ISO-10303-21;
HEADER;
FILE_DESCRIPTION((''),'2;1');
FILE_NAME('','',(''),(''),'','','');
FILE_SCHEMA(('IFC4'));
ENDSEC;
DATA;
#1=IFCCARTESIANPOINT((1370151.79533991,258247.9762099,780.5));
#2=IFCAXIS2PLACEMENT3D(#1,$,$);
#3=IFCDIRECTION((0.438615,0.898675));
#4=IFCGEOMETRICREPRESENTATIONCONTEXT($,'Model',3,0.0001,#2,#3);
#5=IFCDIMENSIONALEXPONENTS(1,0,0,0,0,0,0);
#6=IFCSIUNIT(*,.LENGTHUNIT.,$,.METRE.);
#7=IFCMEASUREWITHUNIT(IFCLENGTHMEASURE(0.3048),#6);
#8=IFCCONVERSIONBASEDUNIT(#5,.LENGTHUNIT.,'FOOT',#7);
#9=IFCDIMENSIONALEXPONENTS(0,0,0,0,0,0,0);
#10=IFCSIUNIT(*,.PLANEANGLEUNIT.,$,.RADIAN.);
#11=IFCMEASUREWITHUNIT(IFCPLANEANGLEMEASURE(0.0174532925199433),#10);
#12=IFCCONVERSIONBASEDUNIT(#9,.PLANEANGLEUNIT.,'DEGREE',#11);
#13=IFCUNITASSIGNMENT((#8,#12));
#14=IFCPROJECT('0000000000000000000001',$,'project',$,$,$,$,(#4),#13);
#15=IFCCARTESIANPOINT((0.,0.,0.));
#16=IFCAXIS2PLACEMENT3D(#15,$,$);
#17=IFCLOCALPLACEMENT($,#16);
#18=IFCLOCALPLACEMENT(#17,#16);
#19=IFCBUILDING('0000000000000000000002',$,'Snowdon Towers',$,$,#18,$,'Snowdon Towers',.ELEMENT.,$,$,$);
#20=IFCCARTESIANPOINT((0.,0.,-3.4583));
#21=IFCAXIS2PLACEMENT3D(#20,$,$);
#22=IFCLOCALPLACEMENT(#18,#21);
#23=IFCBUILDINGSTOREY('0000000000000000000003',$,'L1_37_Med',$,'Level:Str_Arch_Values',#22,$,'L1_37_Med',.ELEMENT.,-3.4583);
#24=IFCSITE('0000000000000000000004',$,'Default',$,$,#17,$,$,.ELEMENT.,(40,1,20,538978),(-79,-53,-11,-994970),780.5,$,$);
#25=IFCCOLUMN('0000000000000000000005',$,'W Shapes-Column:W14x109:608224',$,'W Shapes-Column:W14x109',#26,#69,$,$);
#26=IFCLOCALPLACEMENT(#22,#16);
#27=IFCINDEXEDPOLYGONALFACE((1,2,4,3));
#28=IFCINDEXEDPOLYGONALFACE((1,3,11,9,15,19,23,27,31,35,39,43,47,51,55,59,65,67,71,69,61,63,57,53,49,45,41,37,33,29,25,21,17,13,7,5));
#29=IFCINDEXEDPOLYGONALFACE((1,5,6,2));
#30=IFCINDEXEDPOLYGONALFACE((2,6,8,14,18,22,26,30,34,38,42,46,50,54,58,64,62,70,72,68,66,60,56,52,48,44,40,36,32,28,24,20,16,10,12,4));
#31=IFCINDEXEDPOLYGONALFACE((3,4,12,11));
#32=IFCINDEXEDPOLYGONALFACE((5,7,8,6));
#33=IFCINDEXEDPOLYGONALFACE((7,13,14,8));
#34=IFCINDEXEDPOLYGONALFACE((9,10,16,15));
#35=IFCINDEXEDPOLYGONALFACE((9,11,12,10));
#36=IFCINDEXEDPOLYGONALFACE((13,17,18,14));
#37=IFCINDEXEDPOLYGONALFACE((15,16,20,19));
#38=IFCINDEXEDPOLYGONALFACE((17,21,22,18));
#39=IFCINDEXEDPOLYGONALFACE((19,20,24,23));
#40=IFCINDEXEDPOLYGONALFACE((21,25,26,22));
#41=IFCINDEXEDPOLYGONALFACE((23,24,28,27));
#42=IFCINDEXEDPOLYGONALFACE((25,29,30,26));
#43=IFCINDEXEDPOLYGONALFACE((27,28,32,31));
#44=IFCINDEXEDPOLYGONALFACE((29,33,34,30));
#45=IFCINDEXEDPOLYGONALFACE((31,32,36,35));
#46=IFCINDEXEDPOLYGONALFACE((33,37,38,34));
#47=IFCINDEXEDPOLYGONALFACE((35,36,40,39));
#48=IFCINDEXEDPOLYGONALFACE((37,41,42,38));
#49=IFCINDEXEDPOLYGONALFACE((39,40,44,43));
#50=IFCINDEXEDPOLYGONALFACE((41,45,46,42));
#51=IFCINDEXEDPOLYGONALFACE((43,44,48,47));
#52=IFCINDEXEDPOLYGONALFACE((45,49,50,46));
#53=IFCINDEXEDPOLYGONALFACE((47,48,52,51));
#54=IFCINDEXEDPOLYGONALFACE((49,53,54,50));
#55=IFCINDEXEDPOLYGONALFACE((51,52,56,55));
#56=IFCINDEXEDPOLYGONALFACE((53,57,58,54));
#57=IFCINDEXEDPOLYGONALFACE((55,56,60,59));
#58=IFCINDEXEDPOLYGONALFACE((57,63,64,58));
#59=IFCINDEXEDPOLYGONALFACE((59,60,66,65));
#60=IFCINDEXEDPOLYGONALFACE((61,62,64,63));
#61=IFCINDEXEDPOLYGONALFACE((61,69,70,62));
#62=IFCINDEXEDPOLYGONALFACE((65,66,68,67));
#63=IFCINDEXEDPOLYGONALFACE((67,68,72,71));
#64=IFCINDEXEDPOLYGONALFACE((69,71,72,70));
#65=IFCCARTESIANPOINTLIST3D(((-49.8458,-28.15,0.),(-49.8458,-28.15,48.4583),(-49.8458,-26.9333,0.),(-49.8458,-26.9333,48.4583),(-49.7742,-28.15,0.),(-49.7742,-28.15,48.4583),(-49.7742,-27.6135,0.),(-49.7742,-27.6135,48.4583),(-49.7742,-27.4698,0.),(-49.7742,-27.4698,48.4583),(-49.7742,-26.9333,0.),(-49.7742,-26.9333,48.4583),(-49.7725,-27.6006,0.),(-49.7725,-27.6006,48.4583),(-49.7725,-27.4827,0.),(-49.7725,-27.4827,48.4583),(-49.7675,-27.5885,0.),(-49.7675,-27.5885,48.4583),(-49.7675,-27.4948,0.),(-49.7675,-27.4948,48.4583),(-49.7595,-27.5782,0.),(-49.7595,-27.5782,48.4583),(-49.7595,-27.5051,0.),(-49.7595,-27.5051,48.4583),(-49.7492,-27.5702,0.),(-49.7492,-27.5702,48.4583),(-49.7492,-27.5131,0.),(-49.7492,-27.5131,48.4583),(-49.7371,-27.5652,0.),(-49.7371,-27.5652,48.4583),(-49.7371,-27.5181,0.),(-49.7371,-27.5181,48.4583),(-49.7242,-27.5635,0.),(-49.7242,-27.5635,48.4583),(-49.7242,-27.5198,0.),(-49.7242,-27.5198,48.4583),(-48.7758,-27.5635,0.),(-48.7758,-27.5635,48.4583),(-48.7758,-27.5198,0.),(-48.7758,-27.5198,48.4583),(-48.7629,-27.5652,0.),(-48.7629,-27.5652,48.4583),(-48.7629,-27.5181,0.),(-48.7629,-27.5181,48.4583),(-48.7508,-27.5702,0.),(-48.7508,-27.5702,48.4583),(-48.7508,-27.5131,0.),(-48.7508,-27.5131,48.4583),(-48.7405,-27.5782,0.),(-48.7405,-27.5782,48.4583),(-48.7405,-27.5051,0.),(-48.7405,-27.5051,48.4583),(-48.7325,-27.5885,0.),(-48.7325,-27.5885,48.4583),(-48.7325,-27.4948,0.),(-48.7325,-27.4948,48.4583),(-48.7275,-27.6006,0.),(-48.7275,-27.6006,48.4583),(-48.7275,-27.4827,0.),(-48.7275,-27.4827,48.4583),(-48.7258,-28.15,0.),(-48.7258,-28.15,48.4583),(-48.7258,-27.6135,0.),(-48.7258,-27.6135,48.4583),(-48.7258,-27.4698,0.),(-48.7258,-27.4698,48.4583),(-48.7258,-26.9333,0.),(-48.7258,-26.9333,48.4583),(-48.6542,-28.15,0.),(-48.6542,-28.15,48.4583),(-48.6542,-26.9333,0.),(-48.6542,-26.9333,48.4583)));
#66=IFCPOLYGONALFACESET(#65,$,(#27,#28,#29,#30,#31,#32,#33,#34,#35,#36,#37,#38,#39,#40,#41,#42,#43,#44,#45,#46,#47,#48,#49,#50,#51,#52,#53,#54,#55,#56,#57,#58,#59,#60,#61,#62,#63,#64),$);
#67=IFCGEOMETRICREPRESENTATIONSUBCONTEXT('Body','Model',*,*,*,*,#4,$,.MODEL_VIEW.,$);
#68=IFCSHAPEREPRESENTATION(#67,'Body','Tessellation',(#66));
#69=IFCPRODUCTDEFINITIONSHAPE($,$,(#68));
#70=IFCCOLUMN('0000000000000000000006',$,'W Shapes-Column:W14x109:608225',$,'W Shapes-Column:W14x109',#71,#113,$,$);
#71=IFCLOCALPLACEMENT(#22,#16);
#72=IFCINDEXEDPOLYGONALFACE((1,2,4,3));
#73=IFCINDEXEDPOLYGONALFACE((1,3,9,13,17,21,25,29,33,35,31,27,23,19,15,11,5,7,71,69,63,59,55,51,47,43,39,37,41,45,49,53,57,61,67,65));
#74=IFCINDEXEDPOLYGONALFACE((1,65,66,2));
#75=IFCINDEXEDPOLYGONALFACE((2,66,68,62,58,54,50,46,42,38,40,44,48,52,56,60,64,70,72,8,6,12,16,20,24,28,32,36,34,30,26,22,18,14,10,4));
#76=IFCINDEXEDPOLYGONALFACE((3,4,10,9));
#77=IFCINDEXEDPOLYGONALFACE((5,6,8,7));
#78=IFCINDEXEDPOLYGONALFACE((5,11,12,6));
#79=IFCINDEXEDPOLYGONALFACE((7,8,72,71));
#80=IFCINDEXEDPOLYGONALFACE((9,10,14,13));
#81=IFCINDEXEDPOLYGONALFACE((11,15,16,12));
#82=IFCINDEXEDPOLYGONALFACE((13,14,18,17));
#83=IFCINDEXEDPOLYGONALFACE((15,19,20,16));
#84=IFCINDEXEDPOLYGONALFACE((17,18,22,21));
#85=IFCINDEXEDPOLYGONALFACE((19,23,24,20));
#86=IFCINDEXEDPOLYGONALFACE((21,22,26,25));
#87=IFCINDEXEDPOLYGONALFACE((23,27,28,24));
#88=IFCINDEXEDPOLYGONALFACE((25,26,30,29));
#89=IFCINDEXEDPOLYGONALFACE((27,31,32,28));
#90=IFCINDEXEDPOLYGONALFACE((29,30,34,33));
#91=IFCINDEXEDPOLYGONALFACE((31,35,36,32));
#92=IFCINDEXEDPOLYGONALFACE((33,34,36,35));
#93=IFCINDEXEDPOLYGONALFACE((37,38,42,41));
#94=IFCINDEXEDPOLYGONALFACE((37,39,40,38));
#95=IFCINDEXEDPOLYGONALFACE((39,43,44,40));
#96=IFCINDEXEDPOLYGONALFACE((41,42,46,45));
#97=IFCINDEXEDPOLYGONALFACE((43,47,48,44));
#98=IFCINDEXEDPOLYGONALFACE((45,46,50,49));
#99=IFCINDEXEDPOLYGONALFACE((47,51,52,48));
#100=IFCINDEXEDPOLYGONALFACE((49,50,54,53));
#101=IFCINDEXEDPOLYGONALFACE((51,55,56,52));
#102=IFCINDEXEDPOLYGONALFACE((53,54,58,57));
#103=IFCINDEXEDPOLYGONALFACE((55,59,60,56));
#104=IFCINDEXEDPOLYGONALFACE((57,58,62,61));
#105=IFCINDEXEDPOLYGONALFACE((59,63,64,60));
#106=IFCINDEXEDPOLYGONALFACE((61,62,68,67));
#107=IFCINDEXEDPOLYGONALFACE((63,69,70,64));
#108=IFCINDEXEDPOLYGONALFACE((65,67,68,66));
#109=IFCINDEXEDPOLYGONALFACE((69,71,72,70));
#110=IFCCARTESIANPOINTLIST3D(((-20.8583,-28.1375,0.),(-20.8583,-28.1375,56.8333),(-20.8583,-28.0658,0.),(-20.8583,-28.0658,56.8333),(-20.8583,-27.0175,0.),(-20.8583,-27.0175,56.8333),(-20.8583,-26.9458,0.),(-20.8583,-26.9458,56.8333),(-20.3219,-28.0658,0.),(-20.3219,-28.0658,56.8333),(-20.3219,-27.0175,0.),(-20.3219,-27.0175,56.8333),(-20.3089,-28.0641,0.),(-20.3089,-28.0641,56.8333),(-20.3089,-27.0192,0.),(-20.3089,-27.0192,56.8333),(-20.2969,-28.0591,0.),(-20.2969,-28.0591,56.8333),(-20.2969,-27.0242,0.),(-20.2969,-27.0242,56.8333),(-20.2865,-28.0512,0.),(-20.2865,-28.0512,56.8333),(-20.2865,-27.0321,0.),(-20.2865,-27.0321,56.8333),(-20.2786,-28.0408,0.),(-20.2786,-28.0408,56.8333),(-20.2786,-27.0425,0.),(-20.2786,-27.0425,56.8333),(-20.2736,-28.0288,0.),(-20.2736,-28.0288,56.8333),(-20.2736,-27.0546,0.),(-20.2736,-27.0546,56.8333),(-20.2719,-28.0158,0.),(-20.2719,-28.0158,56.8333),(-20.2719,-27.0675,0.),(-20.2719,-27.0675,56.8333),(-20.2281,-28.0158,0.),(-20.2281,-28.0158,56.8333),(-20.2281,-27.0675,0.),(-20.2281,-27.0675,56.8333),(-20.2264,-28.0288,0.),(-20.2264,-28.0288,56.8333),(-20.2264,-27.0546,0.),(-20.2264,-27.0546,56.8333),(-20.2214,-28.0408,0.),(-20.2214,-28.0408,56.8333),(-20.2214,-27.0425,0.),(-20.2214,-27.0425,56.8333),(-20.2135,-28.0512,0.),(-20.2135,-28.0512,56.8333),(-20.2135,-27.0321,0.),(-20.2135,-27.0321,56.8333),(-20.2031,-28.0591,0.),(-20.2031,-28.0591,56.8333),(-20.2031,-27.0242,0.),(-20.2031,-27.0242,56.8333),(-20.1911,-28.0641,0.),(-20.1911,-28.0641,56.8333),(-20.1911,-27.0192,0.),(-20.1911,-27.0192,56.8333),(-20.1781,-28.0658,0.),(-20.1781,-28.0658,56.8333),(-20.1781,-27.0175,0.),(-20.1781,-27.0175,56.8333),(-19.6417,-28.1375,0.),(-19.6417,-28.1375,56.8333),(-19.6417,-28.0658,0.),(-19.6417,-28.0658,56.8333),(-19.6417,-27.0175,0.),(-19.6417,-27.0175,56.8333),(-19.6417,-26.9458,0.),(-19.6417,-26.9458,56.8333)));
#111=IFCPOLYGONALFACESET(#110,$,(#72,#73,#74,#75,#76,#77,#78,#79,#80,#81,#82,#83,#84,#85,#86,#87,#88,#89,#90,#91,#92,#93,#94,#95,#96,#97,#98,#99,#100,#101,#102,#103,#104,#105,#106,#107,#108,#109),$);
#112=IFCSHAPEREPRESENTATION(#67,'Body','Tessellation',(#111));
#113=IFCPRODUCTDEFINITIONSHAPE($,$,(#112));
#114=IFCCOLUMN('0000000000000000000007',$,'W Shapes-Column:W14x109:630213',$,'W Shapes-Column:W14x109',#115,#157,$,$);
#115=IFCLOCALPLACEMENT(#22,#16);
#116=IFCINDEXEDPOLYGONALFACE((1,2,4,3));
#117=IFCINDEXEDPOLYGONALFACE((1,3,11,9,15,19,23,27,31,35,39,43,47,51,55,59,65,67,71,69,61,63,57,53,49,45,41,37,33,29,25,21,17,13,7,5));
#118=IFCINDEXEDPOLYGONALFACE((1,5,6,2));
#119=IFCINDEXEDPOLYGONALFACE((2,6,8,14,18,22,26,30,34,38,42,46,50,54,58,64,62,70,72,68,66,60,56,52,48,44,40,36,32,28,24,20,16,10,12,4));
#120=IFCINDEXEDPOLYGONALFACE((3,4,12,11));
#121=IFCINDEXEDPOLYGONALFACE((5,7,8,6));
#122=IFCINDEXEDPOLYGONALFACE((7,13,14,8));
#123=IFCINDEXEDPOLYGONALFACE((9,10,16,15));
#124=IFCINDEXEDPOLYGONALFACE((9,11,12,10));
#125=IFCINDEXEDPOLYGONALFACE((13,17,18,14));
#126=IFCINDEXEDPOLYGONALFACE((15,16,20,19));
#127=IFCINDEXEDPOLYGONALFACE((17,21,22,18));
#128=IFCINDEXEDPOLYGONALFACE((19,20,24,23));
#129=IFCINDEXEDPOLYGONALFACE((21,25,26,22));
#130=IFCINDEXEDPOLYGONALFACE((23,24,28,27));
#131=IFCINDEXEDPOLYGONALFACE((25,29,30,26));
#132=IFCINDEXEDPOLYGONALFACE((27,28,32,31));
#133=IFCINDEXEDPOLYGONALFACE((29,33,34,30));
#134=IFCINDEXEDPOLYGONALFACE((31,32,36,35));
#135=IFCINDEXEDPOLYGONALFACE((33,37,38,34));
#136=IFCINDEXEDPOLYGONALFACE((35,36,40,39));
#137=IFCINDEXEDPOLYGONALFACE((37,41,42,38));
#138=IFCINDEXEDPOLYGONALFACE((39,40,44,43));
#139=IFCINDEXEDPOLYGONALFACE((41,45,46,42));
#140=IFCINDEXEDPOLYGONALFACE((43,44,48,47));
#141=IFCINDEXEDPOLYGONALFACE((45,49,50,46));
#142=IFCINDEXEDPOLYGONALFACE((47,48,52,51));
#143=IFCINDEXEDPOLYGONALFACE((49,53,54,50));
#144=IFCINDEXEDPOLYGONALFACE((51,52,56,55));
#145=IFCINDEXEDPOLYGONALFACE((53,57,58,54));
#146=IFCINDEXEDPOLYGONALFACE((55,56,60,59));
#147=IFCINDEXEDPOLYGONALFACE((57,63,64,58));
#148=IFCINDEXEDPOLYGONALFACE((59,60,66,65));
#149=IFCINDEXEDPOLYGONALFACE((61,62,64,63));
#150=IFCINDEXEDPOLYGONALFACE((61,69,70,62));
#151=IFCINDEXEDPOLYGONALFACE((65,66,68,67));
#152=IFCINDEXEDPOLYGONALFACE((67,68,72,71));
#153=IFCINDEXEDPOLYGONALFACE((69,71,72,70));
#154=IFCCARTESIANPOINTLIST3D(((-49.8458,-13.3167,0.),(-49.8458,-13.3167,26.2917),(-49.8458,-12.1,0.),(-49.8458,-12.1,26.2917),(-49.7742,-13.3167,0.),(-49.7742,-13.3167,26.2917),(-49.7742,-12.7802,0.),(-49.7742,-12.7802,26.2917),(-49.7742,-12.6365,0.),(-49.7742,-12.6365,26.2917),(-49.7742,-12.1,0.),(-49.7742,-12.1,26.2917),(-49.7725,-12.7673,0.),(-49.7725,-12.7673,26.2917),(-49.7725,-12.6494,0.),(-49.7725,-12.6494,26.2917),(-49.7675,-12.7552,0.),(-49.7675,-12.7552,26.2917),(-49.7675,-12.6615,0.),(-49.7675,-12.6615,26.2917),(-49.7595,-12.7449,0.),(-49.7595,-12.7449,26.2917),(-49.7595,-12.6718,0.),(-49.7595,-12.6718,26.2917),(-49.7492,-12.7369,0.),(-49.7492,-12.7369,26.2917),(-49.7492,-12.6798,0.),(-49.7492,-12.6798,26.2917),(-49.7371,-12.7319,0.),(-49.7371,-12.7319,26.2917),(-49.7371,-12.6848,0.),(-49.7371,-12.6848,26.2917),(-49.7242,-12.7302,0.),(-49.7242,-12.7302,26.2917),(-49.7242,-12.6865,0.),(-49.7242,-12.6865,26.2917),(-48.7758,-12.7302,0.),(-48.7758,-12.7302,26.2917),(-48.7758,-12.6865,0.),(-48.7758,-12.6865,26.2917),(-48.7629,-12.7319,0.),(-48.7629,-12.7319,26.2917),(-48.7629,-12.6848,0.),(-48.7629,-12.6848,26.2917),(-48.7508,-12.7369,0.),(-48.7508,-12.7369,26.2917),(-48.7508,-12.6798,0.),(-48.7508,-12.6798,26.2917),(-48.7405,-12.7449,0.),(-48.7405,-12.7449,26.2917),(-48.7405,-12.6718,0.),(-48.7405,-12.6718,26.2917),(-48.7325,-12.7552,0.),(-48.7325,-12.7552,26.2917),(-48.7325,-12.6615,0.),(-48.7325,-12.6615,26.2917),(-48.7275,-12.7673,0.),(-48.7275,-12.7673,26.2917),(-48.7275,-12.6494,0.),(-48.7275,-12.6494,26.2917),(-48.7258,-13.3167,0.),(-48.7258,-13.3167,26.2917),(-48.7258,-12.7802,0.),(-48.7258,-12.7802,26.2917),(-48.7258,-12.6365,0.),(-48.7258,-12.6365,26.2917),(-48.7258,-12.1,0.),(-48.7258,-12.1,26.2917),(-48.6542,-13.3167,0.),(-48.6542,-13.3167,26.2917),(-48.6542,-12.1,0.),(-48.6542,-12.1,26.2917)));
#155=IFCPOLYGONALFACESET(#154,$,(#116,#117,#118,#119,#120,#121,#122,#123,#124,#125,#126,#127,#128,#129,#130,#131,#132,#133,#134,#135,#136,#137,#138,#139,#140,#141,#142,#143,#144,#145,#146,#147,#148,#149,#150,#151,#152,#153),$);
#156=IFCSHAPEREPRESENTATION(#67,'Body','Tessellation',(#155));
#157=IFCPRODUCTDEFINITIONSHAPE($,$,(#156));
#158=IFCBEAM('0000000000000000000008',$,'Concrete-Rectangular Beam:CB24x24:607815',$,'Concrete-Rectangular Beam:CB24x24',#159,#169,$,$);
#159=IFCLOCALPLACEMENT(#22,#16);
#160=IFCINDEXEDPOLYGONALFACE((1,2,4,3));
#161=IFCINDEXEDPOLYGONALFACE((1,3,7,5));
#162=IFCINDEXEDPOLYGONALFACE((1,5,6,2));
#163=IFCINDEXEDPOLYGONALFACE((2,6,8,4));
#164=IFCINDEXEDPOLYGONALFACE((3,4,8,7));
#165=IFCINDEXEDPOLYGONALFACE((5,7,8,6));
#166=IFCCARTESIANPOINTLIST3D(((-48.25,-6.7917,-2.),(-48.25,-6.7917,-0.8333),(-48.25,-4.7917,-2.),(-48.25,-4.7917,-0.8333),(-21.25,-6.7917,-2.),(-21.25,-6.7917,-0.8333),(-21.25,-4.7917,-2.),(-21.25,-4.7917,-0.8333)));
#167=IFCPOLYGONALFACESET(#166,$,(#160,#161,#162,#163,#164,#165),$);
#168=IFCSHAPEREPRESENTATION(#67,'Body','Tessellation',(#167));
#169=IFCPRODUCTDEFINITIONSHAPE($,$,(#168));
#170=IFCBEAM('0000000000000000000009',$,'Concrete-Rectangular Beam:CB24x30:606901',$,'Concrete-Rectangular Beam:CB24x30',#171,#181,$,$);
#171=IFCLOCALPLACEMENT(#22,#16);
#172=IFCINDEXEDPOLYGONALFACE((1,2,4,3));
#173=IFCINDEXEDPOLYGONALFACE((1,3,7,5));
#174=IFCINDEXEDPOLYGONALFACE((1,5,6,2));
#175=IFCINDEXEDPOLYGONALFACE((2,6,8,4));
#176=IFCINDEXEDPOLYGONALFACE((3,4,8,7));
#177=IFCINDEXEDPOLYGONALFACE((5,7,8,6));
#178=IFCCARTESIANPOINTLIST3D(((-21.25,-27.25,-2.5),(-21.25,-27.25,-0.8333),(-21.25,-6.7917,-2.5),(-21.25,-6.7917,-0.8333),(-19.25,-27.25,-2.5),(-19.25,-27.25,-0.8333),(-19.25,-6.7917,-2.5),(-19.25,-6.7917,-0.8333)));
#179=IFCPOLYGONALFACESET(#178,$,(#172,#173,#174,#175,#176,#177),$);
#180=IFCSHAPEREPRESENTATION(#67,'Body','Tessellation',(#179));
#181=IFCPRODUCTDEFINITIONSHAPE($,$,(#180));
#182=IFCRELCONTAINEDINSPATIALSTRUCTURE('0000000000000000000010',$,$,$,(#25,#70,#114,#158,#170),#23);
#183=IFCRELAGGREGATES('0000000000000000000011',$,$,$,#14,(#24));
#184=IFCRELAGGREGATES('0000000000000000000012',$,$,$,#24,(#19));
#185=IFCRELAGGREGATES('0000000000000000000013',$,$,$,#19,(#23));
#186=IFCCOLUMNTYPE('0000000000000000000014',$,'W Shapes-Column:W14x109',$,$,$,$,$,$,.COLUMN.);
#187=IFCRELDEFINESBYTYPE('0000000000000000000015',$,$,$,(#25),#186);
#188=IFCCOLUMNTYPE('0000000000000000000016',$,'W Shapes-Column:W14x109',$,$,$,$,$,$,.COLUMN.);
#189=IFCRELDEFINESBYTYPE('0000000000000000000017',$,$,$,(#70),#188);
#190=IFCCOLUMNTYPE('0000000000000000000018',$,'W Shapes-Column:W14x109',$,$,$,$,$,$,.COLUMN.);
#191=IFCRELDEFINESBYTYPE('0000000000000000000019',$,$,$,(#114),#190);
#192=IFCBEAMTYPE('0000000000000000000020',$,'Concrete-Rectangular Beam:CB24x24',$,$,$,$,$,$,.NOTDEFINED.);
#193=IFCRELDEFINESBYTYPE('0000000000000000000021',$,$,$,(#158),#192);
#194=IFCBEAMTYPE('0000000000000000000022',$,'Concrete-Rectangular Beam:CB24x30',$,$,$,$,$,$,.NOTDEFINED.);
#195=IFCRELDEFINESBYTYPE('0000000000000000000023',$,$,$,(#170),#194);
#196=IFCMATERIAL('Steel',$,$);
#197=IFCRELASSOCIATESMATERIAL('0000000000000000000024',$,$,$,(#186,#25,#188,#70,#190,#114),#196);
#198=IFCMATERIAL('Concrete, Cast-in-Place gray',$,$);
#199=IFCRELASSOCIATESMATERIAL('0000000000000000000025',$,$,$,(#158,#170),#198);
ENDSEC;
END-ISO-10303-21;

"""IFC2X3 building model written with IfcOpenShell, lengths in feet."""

from ifc_helpers import new_model, entity, si_unit, converted_unit, direction, frame, frame_2d, origin, place, context, subcontext, project, spatial, rectangle, i_section, extrude, source, transform, mapped, material, type_object, type_shapes, element, save


model = new_model("IFC2X3")

# Units and contexts
model_context = context("Model", 3, precision=0.0001, world=frame((1370151.79533991, 258247.9762099, 780.5)), true_north=direction((0.438615, 0.898675)))
body_context = subcontext(model_context, "Body", "Model", "MODEL_VIEW")
ifc_project = project(units=[converted_unit("LENGTHUNIT", "FOOT", entity("IfcLengthMeasure", 0.3048), si_unit("LENGTHUNIT", "METRE"), dimensions=[1, 0, 0, 0, 0, 0, 0]), converted_unit("PLANEANGLEUNIT", "DEGREE", entity("IfcPlaneAngleMeasure", 0.0174532925199433), si_unit("PLANEANGLEUNIT", "RADIAN"), dimensions=[0, 0, 0, 0, 0, 0, 0])], contexts=[model_context])

# Site, building, storey
site_placement = place(None, origin())
site = spatial("IfcSite", under=ifc_project, at=site_placement, Name="Default", CompositionType="ELEMENT", RefLatitude=(40, 1, 20, 538978), RefLongitude=(-79, -53, -11, -994970), RefElevation=780.5)
building_placement = place(site_placement, origin())
building = spatial("IfcBuilding", under=site, at=building_placement, Name="Snowdon Towers", LongName="Snowdon Towers", CompositionType="ELEMENT")
storey_placement = place(building_placement, frame((0.0, 0.0, -3.4583)))
storey = spatial("IfcBuildingStorey", under=building, at=storey_placement, Name="L1_37_Med", ObjectType="Level:Str_Arch_Values", LongName="L1_37_Med", CompositionType="ELEMENT", Elevation=-3.4583)

# Columns
ifc_material_1 = material(Name="Steel")
column_type_1 = type_object("IfcColumnType", Name="W Shapes-Column:W14x109", PredefinedType="COLUMN", material=ifc_material_1)
shared_shape_1 = source(origin(), body_context, "Body", "SweptSolid", [
    extrude(i_section(OverallWidth=1.2167, OverallDepth=1.1917, WebThickness=0.0438, FlangeThickness=0.0717, FilletRadius=0.05, at=frame_2d((0.0, 0.0), x_axis=(1.0, 0.0))), frame((0.0, 0.0, -3.4583), z_axis=(0.0, 0.0, 1.0), x_axis=(-1.0, 0.0, 0.0)), (0.0, 0.0, 1.0), 48.4583),
])
type_shapes(column_type_1, [shared_shape_1])
column_1_placement = place(storey_placement, frame((-49.25, -27.5417, 3.4583), z_axis=(0.0, 0.0, 1.0), x_axis=(0.0, 1.0, 0.0)))
element("IfcColumn", 1, at=column_1_placement, inside=storey, type_object=column_type_1, material=ifc_material_1, Name="W Shapes-Column:W14x109:608224", ObjectType="W Shapes-Column:W14x109", context=body_context, shape_type="MappedRepresentation", body=[
    mapped(shared_shape_1, transform((0.0, 0.0, 0.0), scale=1.0)),
])
column_type_2 = type_object("IfcColumnType", Name="W Shapes-Column:W14x109", PredefinedType="COLUMN", material=ifc_material_1)
shared_shape_2 = source(origin(), body_context, "Body", "SweptSolid", [
    extrude(i_section(OverallWidth=1.2167, OverallDepth=1.1917, WebThickness=0.0438, FlangeThickness=0.0717, FilletRadius=0.05, at=frame_2d((0.0, 0.0), x_axis=(1.0, 0.0))), frame((0.0, 0.0, -3.4583), z_axis=(0.0, 0.0, 1.0), x_axis=(-1.0, 0.0, 0.0)), (0.0, 0.0, 1.0), 56.8333),
])
type_shapes(column_type_2, [shared_shape_2])
column_2_placement = place(storey_placement, frame((-20.25, -27.5417, 3.4583), z_axis=(0.0, 0.0, 1.0), x_axis=(-1.0, 0.0, 0.0)))
element("IfcColumn", 2, at=column_2_placement, inside=storey, type_object=column_type_2, material=ifc_material_1, Name="W Shapes-Column:W14x109:608225", ObjectType="W Shapes-Column:W14x109", context=body_context, shape_type="MappedRepresentation", body=[
    mapped(shared_shape_2, transform((0.0, 0.0, 0.0), scale=1.0)),
])
column_type_3 = type_object("IfcColumnType", Name="W Shapes-Column:W14x109", PredefinedType="COLUMN", material=ifc_material_1)
shared_shape_3 = source(origin(), body_context, "Body", "SweptSolid", [
    extrude(i_section(OverallWidth=1.2167, OverallDepth=1.1917, WebThickness=0.0438, FlangeThickness=0.0717, FilletRadius=0.05, at=frame_2d((0.0, 0.0), x_axis=(1.0, 0.0))), frame((0.0, 0.0, -3.4583), z_axis=(0.0, 0.0, 1.0), x_axis=(-1.0, 0.0, 0.0)), (0.0, 0.0, 1.0), 26.2917),
])
type_shapes(column_type_3, [shared_shape_3])
column_3_placement = place(storey_placement, frame((-49.25, -12.7083, 3.4583), z_axis=(0.0, 0.0, 1.0), x_axis=(0.0, 1.0, 0.0)))
element("IfcColumn", 3, at=column_3_placement, inside=storey, type_object=column_type_3, material=ifc_material_1, Name="W Shapes-Column:W14x109:630213", ObjectType="W Shapes-Column:W14x109", context=body_context, shape_type="MappedRepresentation", body=[
    mapped(shared_shape_3, transform((0.0, 0.0, 0.0), scale=1.0)),
])

# Beams
ifc_material_2 = material(Name="Concrete, Cast-in-Place gray")
beam_type_1 = type_object("IfcBeamType", Name="Concrete-Rectangular Beam:CB24x24", PredefinedType="NOTDEFINED")
beam_1_placement = place(storey_placement, frame((-49.25, -5.7917, 0.0)))
element("IfcBeam", 4, at=beam_1_placement, inside=storey, type_object=beam_type_1, material=ifc_material_2, Name="Concrete-Rectangular Beam:CB24x24:607815", ObjectType="Concrete-Rectangular Beam:CB24x24", context=body_context, shape_type="SweptSolid", body=[
    extrude(rectangle(XDim=1.1667, YDim=2.0, at=frame_2d((0.0, 0.0), x_axis=(1.0, 0.0))), frame((1.0, 0.0, -1.4167), z_axis=(1.0, 0.0, 0.0), x_axis=(0.0, 0.0, -1.0)), (0.0, 0.0, 1.0), 27.0),
])
beam_type_2 = type_object("IfcBeamType", Name="Concrete-Rectangular Beam:CB24x30", PredefinedType="NOTDEFINED")
beam_2_placement = place(storey_placement, frame((-20.25, -28.25, 0.0), z_axis=(0.0, 0.0, 1.0), x_axis=(0.0, 1.0, 0.0)))
element("IfcBeam", 5, at=beam_2_placement, inside=storey, type_object=beam_type_2, material=ifc_material_2, Name="Concrete-Rectangular Beam:CB24x30:606901", ObjectType="Concrete-Rectangular Beam:CB24x30", context=body_context, shape_type="SweptSolid", body=[
    extrude(rectangle(XDim=1.6667, YDim=2.0, at=frame_2d((0.0, 0.0), x_axis=(1.0, 0.0))), frame((1.0, 0.0, -1.6667), z_axis=(1.0, 0.0, 0.0), x_axis=(0.0, 0.0, -1.0)), (0.0, 0.0, 1.0), 20.4583),
])

save(model, "model.ifc")
